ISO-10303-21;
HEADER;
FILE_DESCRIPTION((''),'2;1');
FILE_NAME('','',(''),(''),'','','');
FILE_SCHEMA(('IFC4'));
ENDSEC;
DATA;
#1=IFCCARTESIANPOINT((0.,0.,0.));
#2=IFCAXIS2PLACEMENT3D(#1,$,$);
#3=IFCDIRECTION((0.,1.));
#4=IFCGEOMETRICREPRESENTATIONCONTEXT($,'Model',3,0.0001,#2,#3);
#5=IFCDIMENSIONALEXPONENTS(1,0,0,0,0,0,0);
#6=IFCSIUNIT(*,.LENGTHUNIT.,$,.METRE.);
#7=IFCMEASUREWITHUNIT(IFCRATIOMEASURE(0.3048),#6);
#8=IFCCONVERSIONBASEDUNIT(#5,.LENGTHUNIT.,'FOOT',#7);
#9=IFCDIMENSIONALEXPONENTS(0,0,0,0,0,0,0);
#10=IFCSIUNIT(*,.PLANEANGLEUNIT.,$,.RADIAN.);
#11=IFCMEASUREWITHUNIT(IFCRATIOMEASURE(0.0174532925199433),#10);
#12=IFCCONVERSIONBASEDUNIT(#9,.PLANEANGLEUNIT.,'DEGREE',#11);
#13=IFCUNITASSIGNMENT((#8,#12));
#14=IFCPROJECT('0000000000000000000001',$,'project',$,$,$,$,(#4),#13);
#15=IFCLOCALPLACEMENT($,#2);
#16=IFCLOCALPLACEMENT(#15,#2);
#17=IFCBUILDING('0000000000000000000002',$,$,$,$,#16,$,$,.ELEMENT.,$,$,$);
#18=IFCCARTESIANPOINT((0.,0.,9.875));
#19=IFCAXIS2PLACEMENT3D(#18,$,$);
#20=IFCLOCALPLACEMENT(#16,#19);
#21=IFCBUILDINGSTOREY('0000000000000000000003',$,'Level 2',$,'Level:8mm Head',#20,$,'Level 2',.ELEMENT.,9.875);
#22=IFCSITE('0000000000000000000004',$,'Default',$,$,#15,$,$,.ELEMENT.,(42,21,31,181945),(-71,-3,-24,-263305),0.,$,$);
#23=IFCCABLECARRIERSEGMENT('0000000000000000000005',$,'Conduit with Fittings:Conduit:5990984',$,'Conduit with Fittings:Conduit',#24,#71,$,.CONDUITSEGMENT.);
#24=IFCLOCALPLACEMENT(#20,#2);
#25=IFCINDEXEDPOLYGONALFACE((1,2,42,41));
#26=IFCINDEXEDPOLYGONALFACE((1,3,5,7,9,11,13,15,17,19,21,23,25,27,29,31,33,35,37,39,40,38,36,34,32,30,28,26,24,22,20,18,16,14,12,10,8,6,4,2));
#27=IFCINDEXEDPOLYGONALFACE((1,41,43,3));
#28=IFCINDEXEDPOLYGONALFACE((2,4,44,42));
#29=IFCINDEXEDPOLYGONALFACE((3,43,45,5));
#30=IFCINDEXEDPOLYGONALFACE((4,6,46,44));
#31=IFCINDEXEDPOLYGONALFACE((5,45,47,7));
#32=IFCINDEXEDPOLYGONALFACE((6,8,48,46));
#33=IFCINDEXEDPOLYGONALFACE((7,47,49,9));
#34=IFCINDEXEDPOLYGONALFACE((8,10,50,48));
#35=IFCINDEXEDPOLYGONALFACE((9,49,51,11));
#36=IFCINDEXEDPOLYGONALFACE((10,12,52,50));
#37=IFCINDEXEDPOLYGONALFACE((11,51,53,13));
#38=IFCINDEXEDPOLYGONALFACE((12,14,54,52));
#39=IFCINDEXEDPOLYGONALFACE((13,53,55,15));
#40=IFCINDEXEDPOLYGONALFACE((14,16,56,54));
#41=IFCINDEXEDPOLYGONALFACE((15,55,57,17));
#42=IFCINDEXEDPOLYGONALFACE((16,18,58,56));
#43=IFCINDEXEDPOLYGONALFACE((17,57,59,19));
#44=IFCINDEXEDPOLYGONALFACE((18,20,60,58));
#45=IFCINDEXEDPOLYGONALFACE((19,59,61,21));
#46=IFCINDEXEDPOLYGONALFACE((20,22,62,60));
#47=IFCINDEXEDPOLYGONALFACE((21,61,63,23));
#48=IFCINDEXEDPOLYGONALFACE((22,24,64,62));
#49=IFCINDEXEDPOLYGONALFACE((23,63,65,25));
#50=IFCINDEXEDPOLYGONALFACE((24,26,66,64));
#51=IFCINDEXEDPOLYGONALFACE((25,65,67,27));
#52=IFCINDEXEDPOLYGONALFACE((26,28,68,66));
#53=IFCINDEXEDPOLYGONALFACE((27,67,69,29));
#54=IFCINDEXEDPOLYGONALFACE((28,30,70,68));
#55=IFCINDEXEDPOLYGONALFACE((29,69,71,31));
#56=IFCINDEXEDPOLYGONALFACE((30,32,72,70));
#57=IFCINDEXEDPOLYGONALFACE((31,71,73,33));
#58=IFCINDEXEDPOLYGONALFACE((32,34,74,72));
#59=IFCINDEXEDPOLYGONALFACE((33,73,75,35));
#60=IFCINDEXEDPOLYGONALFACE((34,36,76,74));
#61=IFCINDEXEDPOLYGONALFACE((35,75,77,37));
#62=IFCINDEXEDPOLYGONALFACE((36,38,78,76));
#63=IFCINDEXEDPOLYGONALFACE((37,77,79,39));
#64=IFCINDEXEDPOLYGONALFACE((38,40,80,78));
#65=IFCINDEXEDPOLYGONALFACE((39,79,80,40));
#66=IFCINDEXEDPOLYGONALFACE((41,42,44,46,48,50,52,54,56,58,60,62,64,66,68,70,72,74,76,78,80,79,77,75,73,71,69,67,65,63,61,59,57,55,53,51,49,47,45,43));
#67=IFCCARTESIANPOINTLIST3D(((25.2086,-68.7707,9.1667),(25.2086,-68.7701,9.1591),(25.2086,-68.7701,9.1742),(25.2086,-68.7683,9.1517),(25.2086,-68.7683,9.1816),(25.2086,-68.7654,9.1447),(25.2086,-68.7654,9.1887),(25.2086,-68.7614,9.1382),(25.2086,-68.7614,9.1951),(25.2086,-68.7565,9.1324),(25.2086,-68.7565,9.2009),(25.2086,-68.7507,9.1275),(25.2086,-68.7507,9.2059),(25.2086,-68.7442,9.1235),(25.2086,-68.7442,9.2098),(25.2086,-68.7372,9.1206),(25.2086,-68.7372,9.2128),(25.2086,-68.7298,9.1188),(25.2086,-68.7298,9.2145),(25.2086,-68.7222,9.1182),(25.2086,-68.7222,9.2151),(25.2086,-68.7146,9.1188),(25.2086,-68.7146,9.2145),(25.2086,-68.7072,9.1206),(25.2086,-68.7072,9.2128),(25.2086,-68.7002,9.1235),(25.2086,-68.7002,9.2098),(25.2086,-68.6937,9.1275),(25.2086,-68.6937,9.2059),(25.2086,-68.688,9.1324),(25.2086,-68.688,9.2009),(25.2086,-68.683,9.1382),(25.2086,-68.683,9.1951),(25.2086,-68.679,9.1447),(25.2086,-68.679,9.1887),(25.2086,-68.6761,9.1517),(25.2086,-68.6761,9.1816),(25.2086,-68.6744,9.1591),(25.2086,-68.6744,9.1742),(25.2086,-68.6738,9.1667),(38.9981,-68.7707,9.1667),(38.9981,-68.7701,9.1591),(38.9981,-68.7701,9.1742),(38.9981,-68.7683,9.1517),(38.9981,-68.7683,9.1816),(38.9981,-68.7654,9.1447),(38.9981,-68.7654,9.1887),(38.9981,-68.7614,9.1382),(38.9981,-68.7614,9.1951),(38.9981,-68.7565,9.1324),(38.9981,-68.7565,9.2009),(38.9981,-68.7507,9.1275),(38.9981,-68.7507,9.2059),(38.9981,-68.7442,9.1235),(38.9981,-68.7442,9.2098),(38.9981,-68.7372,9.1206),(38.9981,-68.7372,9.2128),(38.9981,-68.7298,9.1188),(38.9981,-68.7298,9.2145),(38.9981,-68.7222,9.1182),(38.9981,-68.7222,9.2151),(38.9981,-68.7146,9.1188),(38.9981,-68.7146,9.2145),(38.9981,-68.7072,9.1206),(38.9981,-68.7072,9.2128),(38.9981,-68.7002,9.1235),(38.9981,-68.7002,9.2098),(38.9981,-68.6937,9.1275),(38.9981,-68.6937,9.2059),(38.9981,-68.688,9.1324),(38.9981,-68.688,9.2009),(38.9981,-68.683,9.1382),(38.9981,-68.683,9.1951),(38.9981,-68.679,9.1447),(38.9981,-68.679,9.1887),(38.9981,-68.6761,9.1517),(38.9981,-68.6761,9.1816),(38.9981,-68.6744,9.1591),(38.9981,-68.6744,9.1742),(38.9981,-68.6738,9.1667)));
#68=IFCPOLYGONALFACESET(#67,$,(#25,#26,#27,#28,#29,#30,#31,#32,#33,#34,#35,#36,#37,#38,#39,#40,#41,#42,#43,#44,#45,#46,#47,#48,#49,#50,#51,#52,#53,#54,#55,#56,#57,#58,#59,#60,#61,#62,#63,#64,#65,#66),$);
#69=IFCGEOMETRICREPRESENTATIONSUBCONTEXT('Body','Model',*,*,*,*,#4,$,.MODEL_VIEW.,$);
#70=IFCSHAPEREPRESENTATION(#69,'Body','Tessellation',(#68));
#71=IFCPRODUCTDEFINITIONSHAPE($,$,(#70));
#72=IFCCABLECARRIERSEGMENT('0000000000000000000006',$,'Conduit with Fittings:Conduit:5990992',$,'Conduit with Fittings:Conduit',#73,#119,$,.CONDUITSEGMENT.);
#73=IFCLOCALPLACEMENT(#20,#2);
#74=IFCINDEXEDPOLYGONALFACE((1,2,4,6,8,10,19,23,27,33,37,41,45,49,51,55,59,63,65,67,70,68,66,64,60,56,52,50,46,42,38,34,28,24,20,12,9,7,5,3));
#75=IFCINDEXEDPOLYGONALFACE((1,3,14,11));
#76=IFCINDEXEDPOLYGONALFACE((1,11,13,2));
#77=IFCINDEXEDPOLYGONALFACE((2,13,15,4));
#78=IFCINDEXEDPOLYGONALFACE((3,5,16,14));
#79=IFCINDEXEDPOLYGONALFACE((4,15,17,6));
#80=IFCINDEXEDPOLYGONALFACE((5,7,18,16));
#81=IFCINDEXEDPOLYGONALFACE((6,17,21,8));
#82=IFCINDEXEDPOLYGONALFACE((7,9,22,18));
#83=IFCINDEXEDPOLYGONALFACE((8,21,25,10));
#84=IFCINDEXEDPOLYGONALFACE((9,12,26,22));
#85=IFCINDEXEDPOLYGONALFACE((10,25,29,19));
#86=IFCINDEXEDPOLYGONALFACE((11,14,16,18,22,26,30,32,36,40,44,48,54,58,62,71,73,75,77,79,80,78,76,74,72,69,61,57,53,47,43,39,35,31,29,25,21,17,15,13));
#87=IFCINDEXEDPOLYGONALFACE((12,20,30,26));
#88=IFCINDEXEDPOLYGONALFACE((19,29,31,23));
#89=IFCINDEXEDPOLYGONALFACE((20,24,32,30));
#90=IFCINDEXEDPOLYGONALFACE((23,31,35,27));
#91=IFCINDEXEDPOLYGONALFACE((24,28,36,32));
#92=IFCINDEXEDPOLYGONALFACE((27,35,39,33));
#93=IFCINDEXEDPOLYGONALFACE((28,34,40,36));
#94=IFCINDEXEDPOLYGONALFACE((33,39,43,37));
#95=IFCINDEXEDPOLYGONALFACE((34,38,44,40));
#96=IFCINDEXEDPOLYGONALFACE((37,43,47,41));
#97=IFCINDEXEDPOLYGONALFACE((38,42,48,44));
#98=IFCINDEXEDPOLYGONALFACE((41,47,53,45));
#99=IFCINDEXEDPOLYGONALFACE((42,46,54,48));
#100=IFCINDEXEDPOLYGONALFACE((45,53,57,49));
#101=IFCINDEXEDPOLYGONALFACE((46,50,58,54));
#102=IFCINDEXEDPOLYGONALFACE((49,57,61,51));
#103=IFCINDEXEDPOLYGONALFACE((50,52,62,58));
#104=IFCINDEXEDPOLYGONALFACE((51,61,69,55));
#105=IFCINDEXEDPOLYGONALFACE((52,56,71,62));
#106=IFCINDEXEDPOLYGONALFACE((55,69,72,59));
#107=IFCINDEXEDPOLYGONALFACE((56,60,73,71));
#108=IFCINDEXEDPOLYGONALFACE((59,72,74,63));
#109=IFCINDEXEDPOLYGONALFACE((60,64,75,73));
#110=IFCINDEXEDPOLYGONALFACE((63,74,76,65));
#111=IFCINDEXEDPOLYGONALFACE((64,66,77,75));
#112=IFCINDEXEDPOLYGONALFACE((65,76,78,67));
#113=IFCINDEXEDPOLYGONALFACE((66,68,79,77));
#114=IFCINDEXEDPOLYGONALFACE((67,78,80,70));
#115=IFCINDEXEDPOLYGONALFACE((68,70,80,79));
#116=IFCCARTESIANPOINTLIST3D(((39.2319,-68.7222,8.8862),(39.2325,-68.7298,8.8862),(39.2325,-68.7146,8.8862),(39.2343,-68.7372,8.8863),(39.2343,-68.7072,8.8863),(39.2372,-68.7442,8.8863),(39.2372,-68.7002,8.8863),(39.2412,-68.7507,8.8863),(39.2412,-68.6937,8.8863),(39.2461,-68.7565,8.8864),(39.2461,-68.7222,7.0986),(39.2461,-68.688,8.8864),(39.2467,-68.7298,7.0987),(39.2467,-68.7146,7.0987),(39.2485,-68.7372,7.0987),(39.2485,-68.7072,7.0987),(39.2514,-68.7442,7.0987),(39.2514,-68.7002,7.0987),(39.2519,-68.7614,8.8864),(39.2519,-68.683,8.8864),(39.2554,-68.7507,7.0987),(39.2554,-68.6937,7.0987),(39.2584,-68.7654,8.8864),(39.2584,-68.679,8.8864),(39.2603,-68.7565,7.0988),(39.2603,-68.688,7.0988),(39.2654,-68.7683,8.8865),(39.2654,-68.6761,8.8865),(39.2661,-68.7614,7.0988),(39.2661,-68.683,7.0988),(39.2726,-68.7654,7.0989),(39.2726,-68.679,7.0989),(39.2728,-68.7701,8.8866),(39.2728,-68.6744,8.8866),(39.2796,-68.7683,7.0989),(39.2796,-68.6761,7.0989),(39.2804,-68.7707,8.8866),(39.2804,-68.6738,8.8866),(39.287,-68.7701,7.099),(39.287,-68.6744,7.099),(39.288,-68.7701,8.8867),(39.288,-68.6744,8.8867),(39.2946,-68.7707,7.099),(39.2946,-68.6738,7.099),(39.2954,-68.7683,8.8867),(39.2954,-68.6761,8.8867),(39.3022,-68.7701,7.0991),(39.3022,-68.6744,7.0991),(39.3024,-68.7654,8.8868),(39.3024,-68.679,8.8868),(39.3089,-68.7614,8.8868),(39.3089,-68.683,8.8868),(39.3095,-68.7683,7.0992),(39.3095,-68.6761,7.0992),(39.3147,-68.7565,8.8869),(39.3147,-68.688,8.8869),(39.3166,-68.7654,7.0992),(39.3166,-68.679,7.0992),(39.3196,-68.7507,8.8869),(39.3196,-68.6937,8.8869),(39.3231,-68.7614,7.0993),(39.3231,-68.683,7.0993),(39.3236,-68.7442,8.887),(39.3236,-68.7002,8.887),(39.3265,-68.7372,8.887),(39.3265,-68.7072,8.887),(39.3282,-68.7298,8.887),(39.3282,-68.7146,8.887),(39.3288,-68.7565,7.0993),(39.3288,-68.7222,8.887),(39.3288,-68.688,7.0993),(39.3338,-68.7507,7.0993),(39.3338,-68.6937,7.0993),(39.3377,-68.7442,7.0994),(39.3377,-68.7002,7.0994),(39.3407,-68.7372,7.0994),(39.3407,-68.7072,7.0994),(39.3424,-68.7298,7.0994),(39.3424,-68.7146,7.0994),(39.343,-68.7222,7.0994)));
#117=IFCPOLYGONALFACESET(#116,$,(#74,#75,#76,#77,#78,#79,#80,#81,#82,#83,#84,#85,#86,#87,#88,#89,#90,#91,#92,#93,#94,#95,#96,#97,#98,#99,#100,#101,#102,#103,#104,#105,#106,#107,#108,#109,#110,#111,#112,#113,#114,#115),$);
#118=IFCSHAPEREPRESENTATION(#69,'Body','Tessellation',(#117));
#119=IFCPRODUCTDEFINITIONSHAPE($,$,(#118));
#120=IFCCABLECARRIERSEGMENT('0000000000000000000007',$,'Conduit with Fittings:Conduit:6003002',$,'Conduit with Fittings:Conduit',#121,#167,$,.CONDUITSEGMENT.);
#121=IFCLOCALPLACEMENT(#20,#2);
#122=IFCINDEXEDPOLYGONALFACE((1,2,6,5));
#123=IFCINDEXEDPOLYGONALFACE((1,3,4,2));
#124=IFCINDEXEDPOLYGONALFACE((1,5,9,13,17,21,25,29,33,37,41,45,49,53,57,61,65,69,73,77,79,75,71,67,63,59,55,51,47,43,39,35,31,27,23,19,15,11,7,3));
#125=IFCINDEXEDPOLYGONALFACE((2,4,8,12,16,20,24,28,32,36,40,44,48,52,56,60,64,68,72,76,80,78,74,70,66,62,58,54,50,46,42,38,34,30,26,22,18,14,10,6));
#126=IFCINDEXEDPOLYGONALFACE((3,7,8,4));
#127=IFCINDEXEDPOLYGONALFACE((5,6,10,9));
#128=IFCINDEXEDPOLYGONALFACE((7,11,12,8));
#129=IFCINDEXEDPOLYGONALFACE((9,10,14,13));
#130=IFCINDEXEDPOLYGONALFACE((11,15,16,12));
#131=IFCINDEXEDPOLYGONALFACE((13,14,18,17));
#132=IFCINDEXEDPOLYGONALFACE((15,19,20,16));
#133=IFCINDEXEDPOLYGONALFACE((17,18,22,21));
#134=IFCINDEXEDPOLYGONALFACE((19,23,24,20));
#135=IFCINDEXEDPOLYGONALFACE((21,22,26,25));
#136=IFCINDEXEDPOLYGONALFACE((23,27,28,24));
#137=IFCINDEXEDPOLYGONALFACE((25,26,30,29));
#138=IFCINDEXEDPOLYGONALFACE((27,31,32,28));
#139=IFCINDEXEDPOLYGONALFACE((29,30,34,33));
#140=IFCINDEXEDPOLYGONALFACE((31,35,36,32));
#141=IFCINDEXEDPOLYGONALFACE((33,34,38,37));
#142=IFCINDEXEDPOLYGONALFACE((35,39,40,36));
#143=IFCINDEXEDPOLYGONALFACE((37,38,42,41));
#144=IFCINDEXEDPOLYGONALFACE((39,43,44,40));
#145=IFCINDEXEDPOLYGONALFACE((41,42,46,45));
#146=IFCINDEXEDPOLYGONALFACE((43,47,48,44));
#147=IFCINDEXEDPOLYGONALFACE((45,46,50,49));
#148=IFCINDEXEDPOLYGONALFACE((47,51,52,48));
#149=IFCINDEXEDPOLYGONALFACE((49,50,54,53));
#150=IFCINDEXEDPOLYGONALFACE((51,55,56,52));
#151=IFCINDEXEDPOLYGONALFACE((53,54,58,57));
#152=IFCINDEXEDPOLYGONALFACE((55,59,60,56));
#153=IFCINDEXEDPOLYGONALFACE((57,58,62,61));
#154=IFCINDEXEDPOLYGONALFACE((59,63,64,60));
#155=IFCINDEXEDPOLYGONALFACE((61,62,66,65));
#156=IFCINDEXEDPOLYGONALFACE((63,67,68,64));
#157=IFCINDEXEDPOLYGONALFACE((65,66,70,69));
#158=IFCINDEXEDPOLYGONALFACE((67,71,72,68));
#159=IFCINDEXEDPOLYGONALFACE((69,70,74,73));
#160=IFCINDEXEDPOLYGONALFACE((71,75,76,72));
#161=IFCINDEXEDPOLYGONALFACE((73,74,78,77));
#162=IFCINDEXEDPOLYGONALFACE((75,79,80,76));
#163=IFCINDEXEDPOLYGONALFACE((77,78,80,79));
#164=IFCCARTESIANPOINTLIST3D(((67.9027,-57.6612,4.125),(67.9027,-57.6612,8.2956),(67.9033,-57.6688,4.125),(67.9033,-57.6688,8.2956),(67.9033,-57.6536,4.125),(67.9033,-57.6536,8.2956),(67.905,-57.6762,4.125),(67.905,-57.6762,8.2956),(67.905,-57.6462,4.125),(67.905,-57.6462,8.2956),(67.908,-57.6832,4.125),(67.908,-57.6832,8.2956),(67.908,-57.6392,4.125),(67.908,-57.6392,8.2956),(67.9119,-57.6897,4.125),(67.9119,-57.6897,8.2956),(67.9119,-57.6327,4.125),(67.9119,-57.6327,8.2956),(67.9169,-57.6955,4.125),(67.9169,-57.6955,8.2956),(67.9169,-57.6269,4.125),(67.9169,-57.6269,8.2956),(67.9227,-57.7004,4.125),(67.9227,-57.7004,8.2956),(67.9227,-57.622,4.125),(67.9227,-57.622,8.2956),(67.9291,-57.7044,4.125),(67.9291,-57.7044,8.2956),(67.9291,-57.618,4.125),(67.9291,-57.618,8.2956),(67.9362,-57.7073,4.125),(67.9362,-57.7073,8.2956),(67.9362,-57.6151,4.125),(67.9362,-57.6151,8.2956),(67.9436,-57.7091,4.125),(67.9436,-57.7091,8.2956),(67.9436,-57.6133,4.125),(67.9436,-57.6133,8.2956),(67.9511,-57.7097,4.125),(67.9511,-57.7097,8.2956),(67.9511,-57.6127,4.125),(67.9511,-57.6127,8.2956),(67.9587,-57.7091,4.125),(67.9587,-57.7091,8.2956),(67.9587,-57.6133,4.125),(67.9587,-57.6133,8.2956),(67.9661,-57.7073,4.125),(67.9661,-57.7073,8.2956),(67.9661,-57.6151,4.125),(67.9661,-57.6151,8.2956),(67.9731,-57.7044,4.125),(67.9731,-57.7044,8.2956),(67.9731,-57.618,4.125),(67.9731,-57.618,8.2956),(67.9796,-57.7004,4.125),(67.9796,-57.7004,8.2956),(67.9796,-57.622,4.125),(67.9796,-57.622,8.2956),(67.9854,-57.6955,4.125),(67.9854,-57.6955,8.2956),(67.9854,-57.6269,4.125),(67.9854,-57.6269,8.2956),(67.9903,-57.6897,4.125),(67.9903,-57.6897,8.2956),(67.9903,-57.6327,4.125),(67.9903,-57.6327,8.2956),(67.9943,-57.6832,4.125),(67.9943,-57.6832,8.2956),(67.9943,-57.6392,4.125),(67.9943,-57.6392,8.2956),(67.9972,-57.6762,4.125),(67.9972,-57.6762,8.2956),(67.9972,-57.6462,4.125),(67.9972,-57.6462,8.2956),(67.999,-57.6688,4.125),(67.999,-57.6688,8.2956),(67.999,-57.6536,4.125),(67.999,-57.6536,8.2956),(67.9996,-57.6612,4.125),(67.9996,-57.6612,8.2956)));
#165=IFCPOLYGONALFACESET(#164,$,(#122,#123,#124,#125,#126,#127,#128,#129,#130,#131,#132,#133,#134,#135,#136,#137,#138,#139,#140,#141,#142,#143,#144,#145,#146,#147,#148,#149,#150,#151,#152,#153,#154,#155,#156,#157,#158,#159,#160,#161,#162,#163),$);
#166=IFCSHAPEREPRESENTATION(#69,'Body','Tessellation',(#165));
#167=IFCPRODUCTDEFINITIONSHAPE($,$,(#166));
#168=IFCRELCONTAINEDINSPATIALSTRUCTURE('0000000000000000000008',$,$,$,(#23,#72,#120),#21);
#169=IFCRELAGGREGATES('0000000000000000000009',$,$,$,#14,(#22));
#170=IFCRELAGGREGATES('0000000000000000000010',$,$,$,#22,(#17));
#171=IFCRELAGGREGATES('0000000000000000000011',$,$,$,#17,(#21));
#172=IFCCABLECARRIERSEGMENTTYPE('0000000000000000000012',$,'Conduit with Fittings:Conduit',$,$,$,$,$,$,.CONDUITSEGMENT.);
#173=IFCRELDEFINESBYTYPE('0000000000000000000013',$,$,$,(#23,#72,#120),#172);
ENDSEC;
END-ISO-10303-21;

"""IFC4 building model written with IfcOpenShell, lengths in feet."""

from ifc_helpers import new_model, entity, si_unit, converted_unit, direction, frame, origin, place, context, subcontext, project, spatial, indexed_curve, outline, extrude, type_object, element, save


model = new_model("IFC4")

# Units and contexts
model_context = context("Model", 3, precision=0.0001, world=origin(), true_north=direction((0.0, 1.0)))
body_context = subcontext(model_context, "Body", "Model", "MODEL_VIEW")
ifc_project = project(units=[converted_unit("LENGTHUNIT", "FOOT", entity("IfcRatioMeasure", 0.3048), si_unit("LENGTHUNIT", "METRE"), dimensions=[1, 0, 0, 0, 0, 0, 0]), converted_unit("PLANEANGLEUNIT", "DEGREE", entity("IfcRatioMeasure", 0.0174532925199433), si_unit("PLANEANGLEUNIT", "RADIAN"), dimensions=[0, 0, 0, 0, 0, 0, 0])], contexts=[model_context])

# Site, building, storey
site_placement = place(None, origin())
site = spatial("IfcSite", under=ifc_project, at=site_placement, Name="Default", CompositionType="ELEMENT", RefLatitude=(42, 21, 31, 181945), RefLongitude=(-71, -3, -24, -263305), RefElevation=0.0)
building_placement = place(site_placement, origin())
building = spatial("IfcBuilding", under=site, at=building_placement, CompositionType="ELEMENT")
storey_placement = place(building_placement, frame((0.0, 0.0, 9.875)))
storey = spatial("IfcBuildingStorey", under=building, at=storey_placement, Name="Level 2", ObjectType="Level:8mm Head", LongName="Level 2", CompositionType="ELEMENT", Elevation=9.875)

# Cable carrier segments
cable_carrier_segment_type = type_object("IfcCableCarrierSegmentType", Name="Conduit with Fittings:Conduit", PredefinedType="CONDUITSEGMENT")
cable_carrier_segment_1_placement = place(storey_placement, origin())
element("IfcCableCarrierSegment", 1, at=cable_carrier_segment_1_placement, inside=storey, type_object=cable_carrier_segment_type, Name="Conduit with Fittings:Conduit:5990984", ObjectType="Conduit with Fittings:Conduit", PredefinedType="CONDUITSEGMENT", context=body_context, shape_type="SweptSolid", body=[
    extrude(outline(indexed_curve([(0.0485, 0.0), (0.0479, 0.0076), (0.0461, 0.015), (0.0432, 0.022), (0.0392, 0.0285), (0.0343, 0.0343), (0.0285, 0.0392), (0.022, 0.0432), (0.015, 0.0461), (0.0076, 0.0479), (0.0, 0.0485), (-0.0076, 0.0479), (-0.015, 0.0461), (-0.022, 0.0432), (-0.0285, 0.0392), (-0.0343, 0.0343), (-0.0392, 0.0285), (-0.0432, 0.022), (-0.0461, 0.015), (-0.0479, 0.0076), (-0.0485, 0.0), (-0.0479, -0.0076), (-0.0461, -0.015), (-0.0432, -0.022), (-0.0392, -0.0285), (-0.0343, -0.0343), (-0.0285, -0.0392), (-0.022, -0.0432), (-0.015, -0.0461), (-0.0076, -0.0479), (0.0, -0.0485), (0.0076, -0.0479), (0.015, -0.0461), (0.022, -0.0432), (0.0285, -0.0392), (0.0343, -0.0343), (0.0392, -0.0285), (0.0432, -0.022), (0.0461, -0.015), (0.0479, -0.0076), (0.0485, 0.0)], self_intersect=False)), frame((25.2086, -68.7222, 9.1667), z_axis=(1.0, 0.0, 0.0), x_axis=(0.0, 1.0, 0.0)), (0.0, 0.0, 1.0), 13.7895),
])
cable_carrier_segment_2_placement = place(storey_placement, origin())
element("IfcCableCarrierSegment", 2, at=cable_carrier_segment_2_placement, inside=storey, type_object=cable_carrier_segment_type, Name="Conduit with Fittings:Conduit:5990992", ObjectType="Conduit with Fittings:Conduit", PredefinedType="CONDUITSEGMENT", context=body_context, shape_type="SweptSolid", body=[
    extrude(outline(indexed_curve([(0.0485, 0.0), (0.0479, 0.0076), (0.0461, 0.015), (0.0432, 0.022), (0.0392, 0.0285), (0.0343, 0.0343), (0.0285, 0.0392), (0.022, 0.0432), (0.015, 0.0461), (0.0076, 0.0479), (0.0, 0.0485), (-0.0076, 0.0479), (-0.015, 0.0461), (-0.022, 0.0432), (-0.0285, 0.0392), (-0.0343, 0.0343), (-0.0392, 0.0285), (-0.0432, 0.022), (-0.0461, 0.015), (-0.0479, 0.0076), (-0.0485, 0.0), (-0.0479, -0.0076), (-0.0461, -0.015), (-0.0432, -0.022), (-0.0392, -0.0285), (-0.0343, -0.0343), (-0.0285, -0.0392), (-0.022, -0.0432), (-0.015, -0.0461), (-0.0076, -0.0479), (0.0, -0.0485), (0.0076, -0.0479), (0.015, -0.0461), (0.022, -0.0432), (0.0285, -0.0392), (0.0343, -0.0343), (0.0392, -0.0285), (0.0432, -0.022), (0.0461, -0.015), (0.0479, -0.0076), (0.0485, 0.0)], self_intersect=False)), frame((39.2804, -68.7222, 8.8866), z_axis=(0.007934, 0.0, -0.999969), x_axis=(0.0, -1.0, 0.0)), (0.0, 0.0, 1.0), 1.7876),
])
cable_carrier_segment_3_placement = place(storey_placement, origin())
element("IfcCableCarrierSegment", 3, at=cable_carrier_segment_3_placement, inside=storey, type_object=cable_carrier_segment_type, Name="Conduit with Fittings:Conduit:6003002", ObjectType="Conduit with Fittings:Conduit", PredefinedType="CONDUITSEGMENT", context=body_context, shape_type="SweptSolid", body=[
    extrude(outline(indexed_curve([(0.0485, 0.0), (0.0479, 0.0076), (0.0461, 0.015), (0.0432, 0.022), (0.0392, 0.0285), (0.0343, 0.0343), (0.0285, 0.0392), (0.022, 0.0432), (0.015, 0.0461), (0.0076, 0.0479), (0.0, 0.0485), (-0.0076, 0.0479), (-0.015, 0.0461), (-0.022, 0.0432), (-0.0285, 0.0392), (-0.0343, 0.0343), (-0.0392, 0.0285), (-0.0432, 0.022), (-0.0461, 0.015), (-0.0479, 0.0076), (-0.0485, 0.0), (-0.0479, -0.0076), (-0.0461, -0.015), (-0.0432, -0.022), (-0.0392, -0.0285), (-0.0343, -0.0343), (-0.0285, -0.0392), (-0.022, -0.0432), (-0.015, -0.0461), (-0.0076, -0.0479), (0.0, -0.0485), (0.0076, -0.0479), (0.015, -0.0461), (0.022, -0.0432), (0.0285, -0.0392), (0.0343, -0.0343), (0.0392, -0.0285), (0.0432, -0.022), (0.0461, -0.015), (0.0479, -0.0076), (0.0485, 0.0)], self_intersect=False)), frame((67.9511, -57.6612, 4.125), z_axis=(0.0, 0.0, 1.0), x_axis=(-1.0, 0.0, 0.0)), (0.0, 0.0, 1.0), 4.1706),
])

save(model, "model.ifc")
